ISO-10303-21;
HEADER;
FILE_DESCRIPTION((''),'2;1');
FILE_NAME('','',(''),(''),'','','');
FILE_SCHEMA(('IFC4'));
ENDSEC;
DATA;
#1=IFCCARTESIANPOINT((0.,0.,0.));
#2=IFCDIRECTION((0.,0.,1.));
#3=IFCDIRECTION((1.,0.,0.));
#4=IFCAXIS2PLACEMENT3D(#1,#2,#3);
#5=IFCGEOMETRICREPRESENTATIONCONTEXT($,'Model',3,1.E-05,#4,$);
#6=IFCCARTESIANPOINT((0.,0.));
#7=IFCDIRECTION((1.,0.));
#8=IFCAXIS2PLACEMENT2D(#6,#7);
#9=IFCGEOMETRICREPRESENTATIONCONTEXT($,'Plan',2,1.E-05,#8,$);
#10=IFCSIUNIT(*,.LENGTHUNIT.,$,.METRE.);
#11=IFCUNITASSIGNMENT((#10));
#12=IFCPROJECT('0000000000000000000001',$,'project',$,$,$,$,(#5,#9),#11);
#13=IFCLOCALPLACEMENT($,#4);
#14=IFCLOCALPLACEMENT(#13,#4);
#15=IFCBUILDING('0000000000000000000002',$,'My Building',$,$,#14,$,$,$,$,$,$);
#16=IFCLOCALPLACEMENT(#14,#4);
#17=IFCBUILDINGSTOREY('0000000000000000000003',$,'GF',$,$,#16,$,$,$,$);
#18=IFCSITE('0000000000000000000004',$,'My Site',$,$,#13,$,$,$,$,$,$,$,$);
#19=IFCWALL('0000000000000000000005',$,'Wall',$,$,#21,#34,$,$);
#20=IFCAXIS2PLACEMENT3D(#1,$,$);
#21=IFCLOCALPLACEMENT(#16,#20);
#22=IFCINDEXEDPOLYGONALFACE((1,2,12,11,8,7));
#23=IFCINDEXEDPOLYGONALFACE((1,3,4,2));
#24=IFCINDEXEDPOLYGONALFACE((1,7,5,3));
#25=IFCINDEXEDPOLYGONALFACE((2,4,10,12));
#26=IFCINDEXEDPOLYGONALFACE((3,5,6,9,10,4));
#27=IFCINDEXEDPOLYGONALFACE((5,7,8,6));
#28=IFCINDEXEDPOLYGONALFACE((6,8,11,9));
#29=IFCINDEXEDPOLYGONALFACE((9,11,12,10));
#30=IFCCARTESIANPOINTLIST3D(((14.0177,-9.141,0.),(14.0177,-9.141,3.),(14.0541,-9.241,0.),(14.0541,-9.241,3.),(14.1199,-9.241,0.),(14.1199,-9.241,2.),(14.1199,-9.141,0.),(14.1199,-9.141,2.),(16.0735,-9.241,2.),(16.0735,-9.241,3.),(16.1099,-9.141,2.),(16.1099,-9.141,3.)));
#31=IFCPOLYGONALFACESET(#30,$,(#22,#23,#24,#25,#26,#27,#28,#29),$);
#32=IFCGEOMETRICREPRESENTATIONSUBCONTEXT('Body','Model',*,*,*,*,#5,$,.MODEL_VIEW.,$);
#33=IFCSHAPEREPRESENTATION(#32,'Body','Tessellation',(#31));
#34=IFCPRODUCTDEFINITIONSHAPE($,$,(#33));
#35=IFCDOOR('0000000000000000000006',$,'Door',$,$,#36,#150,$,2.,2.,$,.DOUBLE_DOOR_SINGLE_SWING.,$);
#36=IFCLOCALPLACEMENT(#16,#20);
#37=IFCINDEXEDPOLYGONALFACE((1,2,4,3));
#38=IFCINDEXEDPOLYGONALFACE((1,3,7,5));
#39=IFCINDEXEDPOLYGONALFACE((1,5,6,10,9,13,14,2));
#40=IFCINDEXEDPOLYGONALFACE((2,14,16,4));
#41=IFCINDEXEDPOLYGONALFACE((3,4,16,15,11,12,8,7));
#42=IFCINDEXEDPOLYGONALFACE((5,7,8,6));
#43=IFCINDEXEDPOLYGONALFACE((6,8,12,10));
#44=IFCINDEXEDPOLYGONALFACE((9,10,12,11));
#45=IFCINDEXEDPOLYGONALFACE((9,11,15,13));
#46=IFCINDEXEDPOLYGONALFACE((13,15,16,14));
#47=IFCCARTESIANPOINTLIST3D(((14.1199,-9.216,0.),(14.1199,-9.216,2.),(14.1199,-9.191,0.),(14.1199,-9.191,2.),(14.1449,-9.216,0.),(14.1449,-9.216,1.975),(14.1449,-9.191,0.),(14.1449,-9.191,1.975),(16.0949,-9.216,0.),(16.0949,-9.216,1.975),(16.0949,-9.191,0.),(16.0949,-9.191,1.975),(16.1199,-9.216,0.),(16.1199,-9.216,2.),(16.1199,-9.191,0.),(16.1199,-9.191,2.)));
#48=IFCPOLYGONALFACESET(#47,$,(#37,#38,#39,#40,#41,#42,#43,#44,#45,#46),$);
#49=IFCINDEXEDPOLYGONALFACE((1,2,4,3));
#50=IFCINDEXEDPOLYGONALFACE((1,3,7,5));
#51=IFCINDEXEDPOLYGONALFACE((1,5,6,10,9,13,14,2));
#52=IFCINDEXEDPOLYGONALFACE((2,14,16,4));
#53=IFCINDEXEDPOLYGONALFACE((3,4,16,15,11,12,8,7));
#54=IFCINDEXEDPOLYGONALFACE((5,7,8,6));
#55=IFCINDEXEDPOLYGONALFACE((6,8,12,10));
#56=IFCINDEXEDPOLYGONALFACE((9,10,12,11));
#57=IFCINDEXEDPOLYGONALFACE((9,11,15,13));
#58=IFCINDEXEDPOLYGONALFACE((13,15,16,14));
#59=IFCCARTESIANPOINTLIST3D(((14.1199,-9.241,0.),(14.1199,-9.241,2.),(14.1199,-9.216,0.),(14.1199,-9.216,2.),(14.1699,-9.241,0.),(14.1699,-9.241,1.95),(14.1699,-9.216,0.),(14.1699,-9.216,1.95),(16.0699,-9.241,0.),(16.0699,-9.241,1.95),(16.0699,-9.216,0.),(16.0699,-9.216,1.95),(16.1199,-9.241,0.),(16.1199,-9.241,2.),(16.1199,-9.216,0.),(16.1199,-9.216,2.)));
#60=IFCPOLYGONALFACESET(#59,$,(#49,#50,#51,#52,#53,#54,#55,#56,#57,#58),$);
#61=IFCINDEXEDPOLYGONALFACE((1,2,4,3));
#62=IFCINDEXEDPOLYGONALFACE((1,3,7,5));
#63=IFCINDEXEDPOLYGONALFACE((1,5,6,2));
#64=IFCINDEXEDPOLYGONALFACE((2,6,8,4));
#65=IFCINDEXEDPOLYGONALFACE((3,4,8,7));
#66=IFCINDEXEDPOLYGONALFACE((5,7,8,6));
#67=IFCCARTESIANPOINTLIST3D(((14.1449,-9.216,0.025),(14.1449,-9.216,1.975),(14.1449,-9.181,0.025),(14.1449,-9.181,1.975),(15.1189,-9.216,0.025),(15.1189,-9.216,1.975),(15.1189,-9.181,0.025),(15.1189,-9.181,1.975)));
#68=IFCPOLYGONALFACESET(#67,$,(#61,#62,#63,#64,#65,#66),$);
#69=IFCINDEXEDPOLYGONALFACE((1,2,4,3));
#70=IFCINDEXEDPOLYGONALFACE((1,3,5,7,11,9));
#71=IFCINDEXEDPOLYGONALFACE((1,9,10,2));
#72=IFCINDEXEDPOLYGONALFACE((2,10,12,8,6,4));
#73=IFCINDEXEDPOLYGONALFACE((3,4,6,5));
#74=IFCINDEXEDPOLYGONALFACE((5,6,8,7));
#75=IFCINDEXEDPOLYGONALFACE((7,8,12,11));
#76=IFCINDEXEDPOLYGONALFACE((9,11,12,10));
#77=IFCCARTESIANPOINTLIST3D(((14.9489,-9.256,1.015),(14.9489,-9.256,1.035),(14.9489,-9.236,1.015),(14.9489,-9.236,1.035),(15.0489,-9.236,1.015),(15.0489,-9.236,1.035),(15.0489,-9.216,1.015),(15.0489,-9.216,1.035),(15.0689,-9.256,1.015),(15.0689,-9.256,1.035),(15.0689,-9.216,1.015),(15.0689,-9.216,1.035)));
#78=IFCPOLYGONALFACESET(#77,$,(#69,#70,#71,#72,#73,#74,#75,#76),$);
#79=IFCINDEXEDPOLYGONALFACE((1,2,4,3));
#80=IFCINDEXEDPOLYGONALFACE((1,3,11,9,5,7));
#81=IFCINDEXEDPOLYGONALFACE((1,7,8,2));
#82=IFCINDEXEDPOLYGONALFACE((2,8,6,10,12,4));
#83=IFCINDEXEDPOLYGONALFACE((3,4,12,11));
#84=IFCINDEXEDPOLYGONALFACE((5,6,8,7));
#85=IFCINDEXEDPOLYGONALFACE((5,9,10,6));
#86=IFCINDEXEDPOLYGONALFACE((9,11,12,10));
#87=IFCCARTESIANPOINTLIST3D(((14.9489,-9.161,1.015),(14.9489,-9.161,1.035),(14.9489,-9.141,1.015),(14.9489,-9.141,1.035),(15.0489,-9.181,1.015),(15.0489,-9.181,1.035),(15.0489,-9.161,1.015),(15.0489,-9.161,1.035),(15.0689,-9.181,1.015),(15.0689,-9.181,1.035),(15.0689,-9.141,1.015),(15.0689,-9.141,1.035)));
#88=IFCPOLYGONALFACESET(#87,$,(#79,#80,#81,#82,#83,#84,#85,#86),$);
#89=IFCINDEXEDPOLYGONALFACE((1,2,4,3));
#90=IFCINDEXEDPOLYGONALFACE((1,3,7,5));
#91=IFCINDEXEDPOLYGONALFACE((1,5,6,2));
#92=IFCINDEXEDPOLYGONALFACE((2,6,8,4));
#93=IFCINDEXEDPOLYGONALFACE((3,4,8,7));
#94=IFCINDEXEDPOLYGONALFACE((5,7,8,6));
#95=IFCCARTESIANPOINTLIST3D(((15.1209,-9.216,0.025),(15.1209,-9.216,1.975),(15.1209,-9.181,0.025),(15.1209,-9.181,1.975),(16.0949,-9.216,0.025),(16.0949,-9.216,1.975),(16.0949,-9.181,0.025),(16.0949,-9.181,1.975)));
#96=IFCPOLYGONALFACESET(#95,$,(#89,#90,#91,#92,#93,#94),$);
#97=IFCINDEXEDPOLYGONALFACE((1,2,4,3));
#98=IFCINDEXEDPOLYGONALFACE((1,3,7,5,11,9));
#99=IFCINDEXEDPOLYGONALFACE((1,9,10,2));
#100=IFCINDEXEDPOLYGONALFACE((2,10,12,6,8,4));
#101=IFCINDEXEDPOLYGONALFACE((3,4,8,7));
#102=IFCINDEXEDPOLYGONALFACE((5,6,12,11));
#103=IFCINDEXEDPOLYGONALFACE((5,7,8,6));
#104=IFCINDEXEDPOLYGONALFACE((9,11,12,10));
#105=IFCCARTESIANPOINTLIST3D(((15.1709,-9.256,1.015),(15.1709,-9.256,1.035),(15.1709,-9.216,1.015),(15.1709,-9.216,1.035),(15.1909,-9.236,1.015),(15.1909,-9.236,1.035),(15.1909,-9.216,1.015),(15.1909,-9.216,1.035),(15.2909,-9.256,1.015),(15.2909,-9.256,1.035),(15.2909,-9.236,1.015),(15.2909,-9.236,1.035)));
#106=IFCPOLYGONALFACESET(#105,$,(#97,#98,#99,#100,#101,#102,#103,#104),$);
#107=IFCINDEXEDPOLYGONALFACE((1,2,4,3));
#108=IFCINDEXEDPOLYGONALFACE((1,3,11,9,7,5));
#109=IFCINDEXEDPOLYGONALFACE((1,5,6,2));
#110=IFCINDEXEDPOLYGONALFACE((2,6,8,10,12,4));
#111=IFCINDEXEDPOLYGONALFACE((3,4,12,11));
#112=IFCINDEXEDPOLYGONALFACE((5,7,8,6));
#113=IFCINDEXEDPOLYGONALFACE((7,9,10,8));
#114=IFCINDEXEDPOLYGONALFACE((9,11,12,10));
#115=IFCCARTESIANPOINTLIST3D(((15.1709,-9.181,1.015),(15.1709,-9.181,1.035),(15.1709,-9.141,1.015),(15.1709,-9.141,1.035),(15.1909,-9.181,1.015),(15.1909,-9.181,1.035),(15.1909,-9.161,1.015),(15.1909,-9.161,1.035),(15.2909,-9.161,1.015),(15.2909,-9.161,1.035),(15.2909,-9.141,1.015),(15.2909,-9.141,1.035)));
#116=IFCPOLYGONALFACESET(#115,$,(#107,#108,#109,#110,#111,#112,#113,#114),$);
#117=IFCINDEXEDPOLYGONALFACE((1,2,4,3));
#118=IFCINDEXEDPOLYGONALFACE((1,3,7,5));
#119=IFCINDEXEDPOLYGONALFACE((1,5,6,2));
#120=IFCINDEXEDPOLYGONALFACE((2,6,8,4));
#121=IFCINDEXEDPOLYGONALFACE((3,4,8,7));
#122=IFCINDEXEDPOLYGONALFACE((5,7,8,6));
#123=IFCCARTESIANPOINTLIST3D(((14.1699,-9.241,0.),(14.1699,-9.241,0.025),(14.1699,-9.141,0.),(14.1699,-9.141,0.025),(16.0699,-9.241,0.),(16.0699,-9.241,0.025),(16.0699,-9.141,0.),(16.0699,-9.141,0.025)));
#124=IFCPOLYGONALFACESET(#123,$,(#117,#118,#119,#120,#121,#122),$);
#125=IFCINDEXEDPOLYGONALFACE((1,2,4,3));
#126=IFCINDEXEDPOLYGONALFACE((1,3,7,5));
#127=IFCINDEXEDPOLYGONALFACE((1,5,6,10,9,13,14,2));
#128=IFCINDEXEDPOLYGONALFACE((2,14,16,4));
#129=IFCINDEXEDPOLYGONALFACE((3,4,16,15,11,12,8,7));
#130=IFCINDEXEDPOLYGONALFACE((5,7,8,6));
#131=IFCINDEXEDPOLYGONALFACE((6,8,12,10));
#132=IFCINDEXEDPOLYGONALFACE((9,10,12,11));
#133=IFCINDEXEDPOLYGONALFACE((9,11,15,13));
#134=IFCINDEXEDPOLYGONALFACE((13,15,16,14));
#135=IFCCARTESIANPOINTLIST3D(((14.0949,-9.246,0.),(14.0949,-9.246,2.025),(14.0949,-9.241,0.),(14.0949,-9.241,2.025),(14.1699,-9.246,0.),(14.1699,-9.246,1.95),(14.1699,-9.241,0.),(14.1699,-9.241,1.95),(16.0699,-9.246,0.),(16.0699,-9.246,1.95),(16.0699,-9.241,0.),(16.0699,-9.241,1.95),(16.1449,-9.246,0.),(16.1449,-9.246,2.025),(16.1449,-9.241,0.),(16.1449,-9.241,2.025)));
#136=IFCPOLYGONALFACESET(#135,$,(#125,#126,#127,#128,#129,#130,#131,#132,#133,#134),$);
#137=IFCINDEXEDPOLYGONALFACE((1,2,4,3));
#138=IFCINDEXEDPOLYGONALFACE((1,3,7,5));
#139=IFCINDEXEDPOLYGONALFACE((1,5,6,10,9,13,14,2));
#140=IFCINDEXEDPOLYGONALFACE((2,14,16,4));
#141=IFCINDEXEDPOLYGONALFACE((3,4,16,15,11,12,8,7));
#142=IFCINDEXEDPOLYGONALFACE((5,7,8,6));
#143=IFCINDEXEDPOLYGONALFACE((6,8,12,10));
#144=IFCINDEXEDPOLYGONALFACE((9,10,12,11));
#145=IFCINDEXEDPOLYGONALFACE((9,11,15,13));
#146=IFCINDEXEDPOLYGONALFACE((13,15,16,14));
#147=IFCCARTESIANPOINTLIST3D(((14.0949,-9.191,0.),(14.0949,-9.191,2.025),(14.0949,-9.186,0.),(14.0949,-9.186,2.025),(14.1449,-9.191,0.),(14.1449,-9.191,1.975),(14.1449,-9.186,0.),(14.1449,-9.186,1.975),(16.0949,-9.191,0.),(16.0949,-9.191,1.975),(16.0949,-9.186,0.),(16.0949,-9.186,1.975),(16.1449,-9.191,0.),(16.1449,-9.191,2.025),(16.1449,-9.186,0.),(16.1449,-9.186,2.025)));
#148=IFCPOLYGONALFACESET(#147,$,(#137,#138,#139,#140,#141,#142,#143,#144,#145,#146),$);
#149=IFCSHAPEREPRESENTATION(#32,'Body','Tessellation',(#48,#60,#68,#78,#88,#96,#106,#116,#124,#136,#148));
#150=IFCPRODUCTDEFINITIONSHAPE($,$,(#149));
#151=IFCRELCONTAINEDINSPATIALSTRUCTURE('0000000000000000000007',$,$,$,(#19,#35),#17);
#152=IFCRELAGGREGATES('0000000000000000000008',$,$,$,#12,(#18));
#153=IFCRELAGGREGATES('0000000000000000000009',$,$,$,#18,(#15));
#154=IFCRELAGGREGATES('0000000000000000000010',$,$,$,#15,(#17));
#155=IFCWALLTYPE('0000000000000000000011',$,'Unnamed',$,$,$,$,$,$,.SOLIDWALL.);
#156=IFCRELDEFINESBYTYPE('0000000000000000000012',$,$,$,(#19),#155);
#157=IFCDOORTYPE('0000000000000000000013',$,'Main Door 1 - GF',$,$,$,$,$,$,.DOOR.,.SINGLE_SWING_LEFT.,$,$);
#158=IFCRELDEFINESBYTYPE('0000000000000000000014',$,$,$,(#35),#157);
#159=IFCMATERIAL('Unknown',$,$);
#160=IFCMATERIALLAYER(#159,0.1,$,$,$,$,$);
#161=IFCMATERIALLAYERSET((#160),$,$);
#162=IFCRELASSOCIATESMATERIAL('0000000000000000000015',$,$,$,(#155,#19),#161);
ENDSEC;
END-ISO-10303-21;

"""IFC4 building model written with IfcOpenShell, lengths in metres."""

from ifc_helpers import new_model, entity, si_unit, frame, origin_with_axes, origin_2d_with_axis, place, context, subcontext, project, spatial, line, indexed_curve, outline, extrude, shape, source, transform, mapped, material, layer, layer_set, layer_usage, type_object, type_shapes, element, fill, save


model = new_model("IFC4")

# Units and contexts
model_context = context("Model", 3, precision=1e-05, world=origin_with_axes())
plan_context = context("Plan", 2, precision=1e-05, world=origin_2d_with_axis())
body_context_1 = subcontext(model_context, "Body", "Model", "MODEL_VIEW")
body_context_2 = subcontext(plan_context, "Body", "Plan", "PLAN_VIEW")
ifc_project = project(units=[si_unit("LENGTHUNIT", "METRE")], contexts=[model_context, plan_context])

# Site, building, storey
site_placement = place(None, origin_with_axes())
site = spatial("IfcSite", under=ifc_project, at=site_placement, Name="My Site")
building_placement = place(site_placement, origin_with_axes())
building = spatial("IfcBuilding", under=site, at=building_placement, Name="My Building")
storey_placement = place(building_placement, origin_with_axes())
storey = spatial("IfcBuildingStorey", under=building, at=storey_placement, Name="GF")

# Shared definitions
ifc_material = material(Name="Unknown")

# Shared definitions
ifc_layer_1 = layer(ifc_material, 0.1)
ifc_layer_set_1 = layer_set([ifc_layer_1])
wall_type = type_object("IfcWallType", Name="Unnamed", PredefinedType="SOLIDWALL", material=ifc_layer_set_1)

# Wall, opening, door
ifc_layer_usage_1 = layer_usage(ifc_layer_set_1, "AXIS2", "POSITIVE", 0.0)
wall_1_placement = place(storey_placement, frame((15.9543, -9.141, 0.0), z_axis=(0.0, 0.0, 1.0), x_axis=(-1.0, 0.0, 0.0)))
wall_1 = element("IfcWall", 1, at=wall_1_placement, inside=storey, type_object=wall_type, material=ifc_layer_usage_1, Name="Wall", context=body_context_1, shape_type="SweptSolid", body=[
    extrude(outline(indexed_curve([(-0.1556, 0.0), (-0.1192, 0.1), (1.9002, 0.1), (1.9366, 0.0)], segments=[line(1, 2, 3, 4, 1)])), origin_with_axes(), (0.0, 0.0, 1.0), 3.0),
])
shared_shape_1 = source(origin_with_axes(), body_context_1, "Body", "SweptSolid", [
    extrude(outline(indexed_curve([(0.0, 0.0), (2.0, 0.0), (2.0, 2.0), (0.0, 2.0)], segments=[line(1, 2, 3, 4, 1)])), frame((0.0, -0.6, 0.0), z_axis=(0.0, -1.0, 0.0), x_axis=(1.0, 0.0, 0.0)), (0.0, 0.0, -1.0), 1.2),
])
opening_1_placement = place(wall_1_placement, frame((1.8345, 0.1, 0.0), z_axis=(0.0, 0.0, 1.0), x_axis=(-1.0, 0.0, 0.0)))
opening_1 = element("IfcOpeningElement", 2, at=opening_1_placement, cuts=wall_1, PredefinedType="OPENING", context=body_context_1, shape_type="MappedRepresentation", body=[
    mapped(shared_shape_1, transform((0.0, 0.0, 0.0), x_axis=(1.0, 0.0, 0.0), y_axis=(0.0, 1.0, 0.0), z_axis=(0.0, 0.0, 1.0), scale=1.0)),
])
door_type_1 = type_object("IfcDoorType", Name="Main Door 1 - GF", OperationType="SINGLE_SWING_LEFT", PredefinedType="DOOR")
shared_shape_2 = source(origin_with_axes(), body_context_1, "Body", "SweptSolid", [
    extrude(outline(indexed_curve([(0.0, 0.0), (0.0, 2.0), (2.0, 2.0), (2.0, 0.0), (1.975, 0.0), (1.975, 1.975), (0.025, 1.975), (0.025, 0.0)], segments=[line(1, 2, 3, 4, 5, 6, 7, 8, 1)])), frame((0.0, 0.025, 0.0), z_axis=(0.0, -1.0, 0.0), x_axis=(1.0, 0.0, 0.0)), (0.0, 0.0, -1.0), 0.025),
    extrude(outline(indexed_curve([(0.0, 0.0), (0.0, 2.0), (2.0, 2.0), (2.0, 0.0), (1.95, 0.0), (1.95, 1.95), (0.05, 1.95), (0.05, 0.0)], segments=[line(1, 2, 3, 4, 5, 6, 7, 8, 1)])), frame((0.0, 0.0, 0.0), z_axis=(0.0, -1.0, 0.0), x_axis=(1.0, 0.0, 0.0)), (0.0, 0.0, -1.0), 0.025),
    extrude(outline(indexed_curve([(0.0, 0.0), (0.974, 0.0), (0.974, 0.035), (0.0, 0.035)], segments=[line(1, 2, 3, 4, 1)])), frame((0.025, 0.025, 0.025), z_axis=(0.0, 0.0, 1.0), x_axis=(1.0, 0.0, 0.0)), (0.0, 0.0, 1.0), 1.95),
    extrude(outline(indexed_curve([(0.0, 0.0), (0.0, -0.04), (-0.12, -0.04), (-0.12, -0.02), (-0.02, -0.02), (-0.02, 0.0)], segments=[line(1, 2, 3, 4, 5, 6, 1)])), frame((0.949, 0.025, 1.015), z_axis=(0.0, 0.0, 1.0), x_axis=(1.0, 0.0, 0.0)), (0.0, 0.0, 1.0), 0.02),
    extrude(outline(indexed_curve([(0.0, 0.0), (0.0, 0.04), (-0.12, 0.04), (-0.12, 0.02), (-0.02, 0.02), (-0.02, 0.0)], segments=[line(1, 2, 3, 4, 5, 6, 1)])), frame((0.949, 0.06, 1.015), z_axis=(0.0, 0.0, 1.0), x_axis=(1.0, 0.0, 0.0)), (0.0, 0.0, 1.0), 0.02),
    extrude(outline(indexed_curve([(0.0, 0.0), (-0.974, 0.0), (-0.974, 0.035), (0.0, 0.035)], segments=[line(1, 2, 3, 4, 1)])), frame((1.975, 0.025, 0.025), z_axis=(0.0, 0.0, 1.0), x_axis=(1.0, 0.0, 0.0)), (0.0, 0.0, 1.0), 1.95),
    extrude(outline(indexed_curve([(0.0, 0.0), (0.0, -0.04), (0.12, -0.04), (0.12, -0.02), (0.02, -0.02), (0.02, 0.0)], segments=[line(1, 2, 3, 4, 5, 6, 1)])), frame((1.051, 0.025, 1.015), z_axis=(0.0, 0.0, 1.0), x_axis=(1.0, 0.0, 0.0)), (0.0, 0.0, 1.0), 0.02),
    extrude(outline(indexed_curve([(0.0, 0.0), (0.0, 0.04), (0.12, 0.04), (0.12, 0.02), (0.02, 0.02), (0.02, 0.0)], segments=[line(1, 2, 3, 4, 5, 6, 1)])), frame((1.051, 0.06, 1.015), z_axis=(0.0, 0.0, 1.0), x_axis=(1.0, 0.0, 0.0)), (0.0, 0.0, 1.0), 0.02),
    extrude(outline(indexed_curve([(0.0, 0.0), (1.9, 0.0), (1.9, 0.1), (0.0, 0.1)], segments=[line(1, 2, 3, 4, 1)])), frame((0.05, 0.0, 0.0), z_axis=(0.0, 0.0, 1.0), x_axis=(1.0, 0.0, 0.0)), (0.0, 0.0, 1.0), 0.025),
    extrude(outline(indexed_curve([(0.0, 0.0), (0.0, 2.025), (2.05, 2.025), (2.05, 0.0), (1.975, 0.0), (1.975, 1.95), (0.075, 1.95), (0.075, 0.0)], segments=[line(1, 2, 3, 4, 5, 6, 7, 8, 1)])), frame((-0.025, -0.005, 0.0), z_axis=(0.0, -1.0, 0.0), x_axis=(1.0, 0.0, 0.0)), (0.0, 0.0, -1.0), 0.005),
    extrude(outline(indexed_curve([(0.0, 0.0), (0.0, 2.025), (2.05, 2.025), (2.05, 0.0), (2.0, 0.0), (2.0, 1.975), (0.05, 1.975), (0.05, 0.0)], segments=[line(1, 2, 3, 4, 5, 6, 7, 8, 1)])), frame((-0.025, 0.05, 0.0), z_axis=(0.0, -1.0, 0.0), x_axis=(1.0, 0.0, 0.0)), (0.0, 0.0, -1.0), 0.005),
])
shared_shape_3 = source(origin_with_axes(), body_context_2, "Body", "Curve2D", [
    entity("IfcIndexedPolyCurve", entity("IfcCartesianPointList2D", [[0.0, 0.0], [0.0, 0.05], [0.025, 0.05], [0.025, 0.025], [0.05, 0.025], [0.05, 0.0]]), [entity("IfcLineIndex", [1, 2, 3, 4, 5, 6, 1])]),
    entity("IfcIndexedPolyCurve", entity("IfcCartesianPointList2D", [[2.0, 0.0], [2.0, 0.05], [1.975, 0.05], [1.975, 0.025], [1.95, 0.025], [1.95, 0.0]]), [entity("IfcLineIndex", [1, 2, 3, 4, 5, 6, 1])]),
    entity("IfcTrimmedCurve", entity("IfcEllipse", entity("IfcAxis2Placement2D", entity("IfcCartesianPoint", [0.06, 0.05]), entity("IfcDirection", [1.0, 0.0])), 0.94, 0.975), [entity("IfcCartesianPoint", [1.0, 0.05])], [entity("IfcCartesianPoint", [0.06, 1.025])], True, "CARTESIAN"),
    entity("IfcIndexedPolyCurve", entity("IfcCartesianPointList2D", [[0.025, 0.05], [0.06, 0.05], [0.06, 1.025], [0.025, 1.025]]), [entity("IfcLineIndex", [1, 2, 3, 4, 1])]),
    entity("IfcTrimmedCurve", entity("IfcEllipse", entity("IfcAxis2Placement2D", entity("IfcCartesianPoint", [1.94, 0.05]), entity("IfcDirection", [1.0, 0.0])), 0.94, 0.975), [entity("IfcCartesianPoint", [1.94, 1.025])], [entity("IfcCartesianPoint", [1.0, 0.05])], True, "CARTESIAN"),
    entity("IfcIndexedPolyCurve", entity("IfcCartesianPointList2D", [[1.975, 0.05], [1.94, 0.05], [1.94, 1.025], [1.975, 1.025]]), [entity("IfcLineIndex", [1, 2, 3, 4, 1])]),
])
type_shapes(door_type_1, [shared_shape_2, shared_shape_3])
door_1_placement = place(opening_1_placement, frame((0.0, 0.0, 0.0), z_axis=(0.0, 0.0, 1.0), x_axis=(1.0, 0.0, 0.0)))
door_1 = element("IfcDoor", 3, at=door_1_placement, inside=storey, type_object=door_type_1, Name="Door", OperationType="DOUBLE_DOOR_SINGLE_SWING", OverallHeight=2.0, OverallWidth=2.0, shapes=[
    shape(body_context_1, "Body", "MappedRepresentation", [mapped(shared_shape_2, transform((0.0, 0.0, 0.0), x_axis=(1.0, 0.0, 0.0), y_axis=(0.0, 1.0, 0.0), z_axis=(0.0, 0.0, 1.0), scale=1.0))]),
    shape(body_context_2, "Body", "MappedRepresentation", [mapped(shared_shape_3, transform((0.0, 0.0, 0.0), x_axis=(1.0, 0.0, 0.0), y_axis=(0.0, 1.0, 0.0), z_axis=(0.0, 0.0, 1.0), scale=1.0))]),
])
fill(opening_1, door_1)

save(model, "model.ifc")
